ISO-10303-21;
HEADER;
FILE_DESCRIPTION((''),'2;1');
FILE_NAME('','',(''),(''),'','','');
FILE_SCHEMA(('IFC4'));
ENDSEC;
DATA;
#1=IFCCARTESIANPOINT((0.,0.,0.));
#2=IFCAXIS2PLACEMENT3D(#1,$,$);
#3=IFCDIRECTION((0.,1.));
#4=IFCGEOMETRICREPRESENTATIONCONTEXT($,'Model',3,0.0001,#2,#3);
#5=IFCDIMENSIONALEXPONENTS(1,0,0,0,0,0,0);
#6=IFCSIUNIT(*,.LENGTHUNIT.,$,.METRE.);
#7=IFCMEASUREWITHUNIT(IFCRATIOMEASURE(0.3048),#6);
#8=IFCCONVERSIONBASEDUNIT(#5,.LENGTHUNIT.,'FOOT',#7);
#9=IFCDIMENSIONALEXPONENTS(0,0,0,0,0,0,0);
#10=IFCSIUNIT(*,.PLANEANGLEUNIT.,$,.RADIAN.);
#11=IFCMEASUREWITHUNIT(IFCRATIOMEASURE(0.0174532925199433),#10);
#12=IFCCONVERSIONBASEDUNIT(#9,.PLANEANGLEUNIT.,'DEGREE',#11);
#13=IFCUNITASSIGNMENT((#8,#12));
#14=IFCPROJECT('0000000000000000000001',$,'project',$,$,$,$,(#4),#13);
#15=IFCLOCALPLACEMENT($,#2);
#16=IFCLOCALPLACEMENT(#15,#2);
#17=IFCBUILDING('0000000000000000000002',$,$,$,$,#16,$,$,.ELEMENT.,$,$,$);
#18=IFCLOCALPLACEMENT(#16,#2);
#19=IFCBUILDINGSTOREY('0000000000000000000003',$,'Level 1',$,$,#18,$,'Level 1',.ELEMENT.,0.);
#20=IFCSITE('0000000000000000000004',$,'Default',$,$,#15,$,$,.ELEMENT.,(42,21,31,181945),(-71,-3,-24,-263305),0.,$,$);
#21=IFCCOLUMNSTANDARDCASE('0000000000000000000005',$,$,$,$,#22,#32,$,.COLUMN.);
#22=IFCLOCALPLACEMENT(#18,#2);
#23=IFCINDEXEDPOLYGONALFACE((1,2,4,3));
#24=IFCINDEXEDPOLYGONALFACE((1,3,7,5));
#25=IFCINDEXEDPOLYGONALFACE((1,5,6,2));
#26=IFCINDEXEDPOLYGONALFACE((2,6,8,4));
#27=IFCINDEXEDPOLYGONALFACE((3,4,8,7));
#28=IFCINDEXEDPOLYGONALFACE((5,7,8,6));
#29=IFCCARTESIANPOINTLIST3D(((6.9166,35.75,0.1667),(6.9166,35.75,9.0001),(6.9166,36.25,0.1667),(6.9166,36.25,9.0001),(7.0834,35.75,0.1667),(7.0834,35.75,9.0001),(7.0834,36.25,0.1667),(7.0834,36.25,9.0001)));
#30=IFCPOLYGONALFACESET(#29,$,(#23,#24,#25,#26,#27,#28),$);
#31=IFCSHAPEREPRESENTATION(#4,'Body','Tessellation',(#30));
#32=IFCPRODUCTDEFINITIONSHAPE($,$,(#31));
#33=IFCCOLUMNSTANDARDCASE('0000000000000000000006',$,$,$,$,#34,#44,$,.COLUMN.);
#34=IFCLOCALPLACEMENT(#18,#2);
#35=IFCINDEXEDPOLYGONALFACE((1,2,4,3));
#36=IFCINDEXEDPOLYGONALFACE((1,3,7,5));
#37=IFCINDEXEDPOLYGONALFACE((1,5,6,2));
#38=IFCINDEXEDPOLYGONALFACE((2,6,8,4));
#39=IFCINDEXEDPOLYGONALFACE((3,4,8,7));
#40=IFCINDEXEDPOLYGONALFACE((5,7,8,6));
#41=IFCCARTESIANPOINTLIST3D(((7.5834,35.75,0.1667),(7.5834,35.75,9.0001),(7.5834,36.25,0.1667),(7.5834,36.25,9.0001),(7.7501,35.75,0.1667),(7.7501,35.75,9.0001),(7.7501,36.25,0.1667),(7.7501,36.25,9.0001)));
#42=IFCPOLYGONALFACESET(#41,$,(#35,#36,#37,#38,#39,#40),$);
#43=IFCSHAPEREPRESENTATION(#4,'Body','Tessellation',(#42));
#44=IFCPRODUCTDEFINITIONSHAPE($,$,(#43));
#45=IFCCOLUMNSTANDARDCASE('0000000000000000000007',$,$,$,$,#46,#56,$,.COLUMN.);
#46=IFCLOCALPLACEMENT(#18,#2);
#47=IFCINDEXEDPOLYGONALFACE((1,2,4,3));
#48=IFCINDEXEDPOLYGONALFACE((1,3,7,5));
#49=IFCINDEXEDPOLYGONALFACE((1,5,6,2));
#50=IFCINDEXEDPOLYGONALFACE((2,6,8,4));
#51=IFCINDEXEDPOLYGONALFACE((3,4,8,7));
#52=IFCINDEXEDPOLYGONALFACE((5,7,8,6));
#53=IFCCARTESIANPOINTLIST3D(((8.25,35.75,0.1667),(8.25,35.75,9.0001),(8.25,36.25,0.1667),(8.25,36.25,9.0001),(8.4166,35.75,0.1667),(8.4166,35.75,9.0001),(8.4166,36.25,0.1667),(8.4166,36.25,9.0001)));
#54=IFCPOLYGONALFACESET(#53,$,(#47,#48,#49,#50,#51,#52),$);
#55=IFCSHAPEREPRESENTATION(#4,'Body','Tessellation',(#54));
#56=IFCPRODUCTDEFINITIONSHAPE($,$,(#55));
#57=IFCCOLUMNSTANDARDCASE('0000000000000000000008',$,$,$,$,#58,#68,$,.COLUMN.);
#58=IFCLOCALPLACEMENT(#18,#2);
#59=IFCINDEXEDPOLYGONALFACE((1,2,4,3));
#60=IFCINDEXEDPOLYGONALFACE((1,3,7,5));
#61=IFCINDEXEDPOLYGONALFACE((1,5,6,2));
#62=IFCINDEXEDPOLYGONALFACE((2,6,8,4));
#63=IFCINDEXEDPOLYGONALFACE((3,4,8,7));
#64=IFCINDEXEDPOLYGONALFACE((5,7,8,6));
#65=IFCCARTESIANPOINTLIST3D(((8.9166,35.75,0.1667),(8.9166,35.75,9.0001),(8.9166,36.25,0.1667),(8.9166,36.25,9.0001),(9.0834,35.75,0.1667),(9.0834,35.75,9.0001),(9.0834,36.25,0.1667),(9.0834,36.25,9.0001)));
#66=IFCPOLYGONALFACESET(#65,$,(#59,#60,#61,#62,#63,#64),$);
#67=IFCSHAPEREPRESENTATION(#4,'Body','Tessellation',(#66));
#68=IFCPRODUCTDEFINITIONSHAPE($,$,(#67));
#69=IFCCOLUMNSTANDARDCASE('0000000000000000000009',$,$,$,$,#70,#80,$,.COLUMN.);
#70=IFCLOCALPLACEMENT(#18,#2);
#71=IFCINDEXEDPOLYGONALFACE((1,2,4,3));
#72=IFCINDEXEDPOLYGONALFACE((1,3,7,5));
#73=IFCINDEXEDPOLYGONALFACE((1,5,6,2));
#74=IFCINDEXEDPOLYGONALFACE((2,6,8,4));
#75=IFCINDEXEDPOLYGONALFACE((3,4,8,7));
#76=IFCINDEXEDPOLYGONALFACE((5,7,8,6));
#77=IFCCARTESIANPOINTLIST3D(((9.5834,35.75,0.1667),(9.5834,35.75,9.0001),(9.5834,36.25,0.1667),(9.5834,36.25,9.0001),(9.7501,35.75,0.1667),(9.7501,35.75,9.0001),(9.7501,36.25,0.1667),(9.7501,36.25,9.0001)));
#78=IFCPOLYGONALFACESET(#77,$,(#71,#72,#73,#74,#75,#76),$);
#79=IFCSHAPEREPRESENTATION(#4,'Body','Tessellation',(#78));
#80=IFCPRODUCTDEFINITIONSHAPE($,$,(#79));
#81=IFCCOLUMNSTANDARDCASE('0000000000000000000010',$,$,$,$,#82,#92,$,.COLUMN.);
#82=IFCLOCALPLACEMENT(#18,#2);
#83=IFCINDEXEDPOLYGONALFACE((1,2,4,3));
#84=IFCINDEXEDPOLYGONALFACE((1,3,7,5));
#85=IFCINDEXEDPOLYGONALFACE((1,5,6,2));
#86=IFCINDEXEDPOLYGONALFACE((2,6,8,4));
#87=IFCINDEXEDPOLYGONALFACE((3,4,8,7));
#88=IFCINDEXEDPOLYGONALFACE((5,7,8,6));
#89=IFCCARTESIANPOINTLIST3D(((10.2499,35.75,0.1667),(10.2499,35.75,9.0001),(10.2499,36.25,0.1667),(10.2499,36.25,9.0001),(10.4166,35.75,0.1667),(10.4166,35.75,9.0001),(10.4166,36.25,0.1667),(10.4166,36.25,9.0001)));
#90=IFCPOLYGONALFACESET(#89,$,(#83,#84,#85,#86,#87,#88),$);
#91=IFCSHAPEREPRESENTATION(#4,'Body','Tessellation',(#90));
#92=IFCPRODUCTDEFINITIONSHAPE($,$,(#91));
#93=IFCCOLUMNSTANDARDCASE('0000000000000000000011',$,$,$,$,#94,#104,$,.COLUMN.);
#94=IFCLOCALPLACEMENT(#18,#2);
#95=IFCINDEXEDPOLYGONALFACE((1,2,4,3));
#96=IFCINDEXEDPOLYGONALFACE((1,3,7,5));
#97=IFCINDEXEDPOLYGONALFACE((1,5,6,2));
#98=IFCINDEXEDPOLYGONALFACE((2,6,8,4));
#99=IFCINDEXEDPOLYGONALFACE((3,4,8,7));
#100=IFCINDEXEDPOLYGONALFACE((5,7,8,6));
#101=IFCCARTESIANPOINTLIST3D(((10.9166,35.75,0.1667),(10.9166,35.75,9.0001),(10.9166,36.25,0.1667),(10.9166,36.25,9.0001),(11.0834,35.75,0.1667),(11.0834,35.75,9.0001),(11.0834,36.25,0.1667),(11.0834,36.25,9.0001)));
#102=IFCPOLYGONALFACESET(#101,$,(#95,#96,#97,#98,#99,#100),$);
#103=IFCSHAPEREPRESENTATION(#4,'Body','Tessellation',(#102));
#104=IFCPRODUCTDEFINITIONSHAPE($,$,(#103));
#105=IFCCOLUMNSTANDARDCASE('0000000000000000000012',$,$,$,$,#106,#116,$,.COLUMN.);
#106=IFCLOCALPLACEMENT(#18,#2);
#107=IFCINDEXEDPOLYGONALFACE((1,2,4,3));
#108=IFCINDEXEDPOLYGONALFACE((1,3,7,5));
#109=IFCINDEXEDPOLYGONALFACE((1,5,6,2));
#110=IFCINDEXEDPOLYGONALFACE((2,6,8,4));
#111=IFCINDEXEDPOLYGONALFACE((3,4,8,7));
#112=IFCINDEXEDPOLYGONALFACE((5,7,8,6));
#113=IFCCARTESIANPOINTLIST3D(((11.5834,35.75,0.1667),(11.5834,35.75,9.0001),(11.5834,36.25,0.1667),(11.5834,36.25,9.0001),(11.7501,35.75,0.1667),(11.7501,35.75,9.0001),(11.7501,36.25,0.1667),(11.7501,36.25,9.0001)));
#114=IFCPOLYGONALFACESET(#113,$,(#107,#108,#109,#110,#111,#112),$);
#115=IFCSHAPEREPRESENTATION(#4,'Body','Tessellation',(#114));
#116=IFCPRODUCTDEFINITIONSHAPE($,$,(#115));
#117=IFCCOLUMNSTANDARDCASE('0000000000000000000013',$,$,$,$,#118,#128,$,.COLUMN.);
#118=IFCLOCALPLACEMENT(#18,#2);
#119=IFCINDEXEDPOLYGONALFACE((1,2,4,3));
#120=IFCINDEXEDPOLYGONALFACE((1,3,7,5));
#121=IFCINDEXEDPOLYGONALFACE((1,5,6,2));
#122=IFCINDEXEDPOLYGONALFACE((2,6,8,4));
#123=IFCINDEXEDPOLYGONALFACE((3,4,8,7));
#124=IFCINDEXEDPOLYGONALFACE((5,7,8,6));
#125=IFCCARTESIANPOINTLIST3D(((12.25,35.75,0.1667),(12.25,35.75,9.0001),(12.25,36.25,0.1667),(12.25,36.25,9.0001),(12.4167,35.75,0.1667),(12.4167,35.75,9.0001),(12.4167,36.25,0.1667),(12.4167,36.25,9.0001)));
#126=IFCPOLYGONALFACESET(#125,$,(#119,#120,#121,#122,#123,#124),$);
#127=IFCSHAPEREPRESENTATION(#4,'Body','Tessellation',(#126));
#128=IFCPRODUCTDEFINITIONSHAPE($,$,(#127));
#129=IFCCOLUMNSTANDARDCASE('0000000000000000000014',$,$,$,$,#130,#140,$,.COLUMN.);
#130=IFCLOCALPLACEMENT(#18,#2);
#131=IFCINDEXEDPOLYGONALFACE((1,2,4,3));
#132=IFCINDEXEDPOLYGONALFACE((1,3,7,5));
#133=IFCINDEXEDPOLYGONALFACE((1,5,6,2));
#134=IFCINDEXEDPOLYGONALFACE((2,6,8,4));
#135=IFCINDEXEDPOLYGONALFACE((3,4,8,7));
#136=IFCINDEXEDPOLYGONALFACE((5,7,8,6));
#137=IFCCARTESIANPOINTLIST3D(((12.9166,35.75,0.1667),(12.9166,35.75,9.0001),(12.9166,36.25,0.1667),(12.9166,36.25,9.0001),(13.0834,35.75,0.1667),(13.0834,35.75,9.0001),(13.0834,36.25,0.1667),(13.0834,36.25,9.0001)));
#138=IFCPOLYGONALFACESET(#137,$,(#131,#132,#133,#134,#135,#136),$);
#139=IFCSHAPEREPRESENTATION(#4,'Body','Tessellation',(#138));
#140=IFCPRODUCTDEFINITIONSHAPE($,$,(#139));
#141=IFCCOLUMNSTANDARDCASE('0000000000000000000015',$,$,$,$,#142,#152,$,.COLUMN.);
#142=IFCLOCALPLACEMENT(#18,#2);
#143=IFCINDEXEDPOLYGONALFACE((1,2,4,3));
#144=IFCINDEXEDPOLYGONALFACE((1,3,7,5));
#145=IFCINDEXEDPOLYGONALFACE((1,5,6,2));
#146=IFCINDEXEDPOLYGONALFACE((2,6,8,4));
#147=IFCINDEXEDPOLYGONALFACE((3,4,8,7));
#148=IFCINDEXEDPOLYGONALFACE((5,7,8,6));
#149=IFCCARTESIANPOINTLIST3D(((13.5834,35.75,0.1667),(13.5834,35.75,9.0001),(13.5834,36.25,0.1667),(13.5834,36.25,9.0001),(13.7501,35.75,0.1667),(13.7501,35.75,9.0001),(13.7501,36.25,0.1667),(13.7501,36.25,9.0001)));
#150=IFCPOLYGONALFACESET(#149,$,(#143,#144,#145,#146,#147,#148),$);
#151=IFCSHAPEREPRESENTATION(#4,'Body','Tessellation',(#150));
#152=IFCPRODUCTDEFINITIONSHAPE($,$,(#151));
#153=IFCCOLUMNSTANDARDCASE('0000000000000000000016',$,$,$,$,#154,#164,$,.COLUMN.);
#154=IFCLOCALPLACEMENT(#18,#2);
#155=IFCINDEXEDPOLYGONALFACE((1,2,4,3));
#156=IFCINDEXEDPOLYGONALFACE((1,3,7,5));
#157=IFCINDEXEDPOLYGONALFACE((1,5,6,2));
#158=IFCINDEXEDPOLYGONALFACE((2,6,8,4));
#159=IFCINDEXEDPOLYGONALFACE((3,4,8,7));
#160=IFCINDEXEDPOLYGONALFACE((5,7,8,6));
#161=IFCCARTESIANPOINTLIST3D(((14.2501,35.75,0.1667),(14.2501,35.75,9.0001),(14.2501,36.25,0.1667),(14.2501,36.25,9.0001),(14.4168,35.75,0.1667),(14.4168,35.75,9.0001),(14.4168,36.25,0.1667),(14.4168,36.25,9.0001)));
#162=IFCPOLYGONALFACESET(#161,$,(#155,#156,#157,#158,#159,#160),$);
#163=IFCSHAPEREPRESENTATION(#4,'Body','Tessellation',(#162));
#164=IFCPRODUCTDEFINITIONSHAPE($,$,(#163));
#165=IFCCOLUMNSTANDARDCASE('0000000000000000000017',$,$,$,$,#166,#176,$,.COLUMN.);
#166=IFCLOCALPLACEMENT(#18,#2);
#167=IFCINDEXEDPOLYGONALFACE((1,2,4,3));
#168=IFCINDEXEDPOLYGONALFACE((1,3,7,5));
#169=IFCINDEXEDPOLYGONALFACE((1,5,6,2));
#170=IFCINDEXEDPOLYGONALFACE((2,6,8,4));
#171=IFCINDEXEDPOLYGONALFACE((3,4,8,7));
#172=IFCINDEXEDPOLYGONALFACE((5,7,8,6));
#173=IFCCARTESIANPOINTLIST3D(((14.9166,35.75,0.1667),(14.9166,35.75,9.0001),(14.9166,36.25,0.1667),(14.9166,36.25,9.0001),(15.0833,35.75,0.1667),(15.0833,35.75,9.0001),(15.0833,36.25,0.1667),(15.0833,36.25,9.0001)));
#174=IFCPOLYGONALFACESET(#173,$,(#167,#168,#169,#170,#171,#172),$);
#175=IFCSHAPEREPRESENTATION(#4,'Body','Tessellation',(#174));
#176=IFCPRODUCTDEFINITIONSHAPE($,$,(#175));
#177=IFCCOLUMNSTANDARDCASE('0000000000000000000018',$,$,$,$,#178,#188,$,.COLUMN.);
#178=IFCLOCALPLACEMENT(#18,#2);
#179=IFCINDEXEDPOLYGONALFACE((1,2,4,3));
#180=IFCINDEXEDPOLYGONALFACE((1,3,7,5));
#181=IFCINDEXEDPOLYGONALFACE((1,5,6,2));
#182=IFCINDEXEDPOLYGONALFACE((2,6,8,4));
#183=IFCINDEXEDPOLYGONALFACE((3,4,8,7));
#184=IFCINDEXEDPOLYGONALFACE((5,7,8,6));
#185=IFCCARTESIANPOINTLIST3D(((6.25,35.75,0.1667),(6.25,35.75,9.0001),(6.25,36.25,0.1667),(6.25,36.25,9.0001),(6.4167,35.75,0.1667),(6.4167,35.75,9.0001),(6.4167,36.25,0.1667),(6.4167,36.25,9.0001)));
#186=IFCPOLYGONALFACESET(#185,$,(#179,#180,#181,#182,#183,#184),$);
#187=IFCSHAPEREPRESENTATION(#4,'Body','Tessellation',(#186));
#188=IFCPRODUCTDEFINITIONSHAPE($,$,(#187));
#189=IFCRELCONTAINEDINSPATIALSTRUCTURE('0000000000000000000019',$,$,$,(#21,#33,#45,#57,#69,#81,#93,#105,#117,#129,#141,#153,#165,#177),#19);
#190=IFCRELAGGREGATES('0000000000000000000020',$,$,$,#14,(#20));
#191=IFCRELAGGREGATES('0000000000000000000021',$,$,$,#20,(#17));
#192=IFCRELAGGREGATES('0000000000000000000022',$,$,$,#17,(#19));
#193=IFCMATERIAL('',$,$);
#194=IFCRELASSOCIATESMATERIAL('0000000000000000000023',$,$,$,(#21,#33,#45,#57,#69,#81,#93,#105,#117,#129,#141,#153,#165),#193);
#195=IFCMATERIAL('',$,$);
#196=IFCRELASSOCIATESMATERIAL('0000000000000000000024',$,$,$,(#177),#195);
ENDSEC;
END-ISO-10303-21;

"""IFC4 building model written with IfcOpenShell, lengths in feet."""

from ifc_helpers import new_model, entity, si_unit, converted_unit, direction, frame, origin, place, context, project, spatial, rectangle, extrude, material, element, save


model = new_model("IFC4")

# Units and contexts
model_context = context("Model", 3, precision=0.0001, world=origin(), true_north=direction((0.0, 1.0)))
ifc_project = project(units=[converted_unit("LENGTHUNIT", "FOOT", entity("IfcRatioMeasure", 0.3048), si_unit("LENGTHUNIT", "METRE"), dimensions=[1, 0, 0, 0, 0, 0, 0]), converted_unit("PLANEANGLEUNIT", "DEGREE", entity("IfcRatioMeasure", 0.0174532925199433), si_unit("PLANEANGLEUNIT", "RADIAN"), dimensions=[0, 0, 0, 0, 0, 0, 0])], contexts=[model_context])

# Site, building, storey
site_placement = place(None, origin())
site = spatial("IfcSite", under=ifc_project, at=site_placement, Name="Default", CompositionType="ELEMENT", RefLatitude=(42, 21, 31, 181945), RefLongitude=(-71, -3, -24, -263305), RefElevation=0.0)
building_placement = place(site_placement, origin())
building = spatial("IfcBuilding", under=site, at=building_placement, CompositionType="ELEMENT")
storey_placement = place(building_placement, origin())
storey = spatial("IfcBuildingStorey", under=building, at=storey_placement, Name="Level 1", LongName="Level 1", CompositionType="ELEMENT", Elevation=0.0)

# Columns
ifc_material_1 = material(Name="")
placement = place(storey_placement, frame((0.25, 36.0, 0.0)))
for number, where, z_axis, x_axis in (
    (1, (6.75, 0.0, 0.1667), (0.0, 0.0, 1.0), (1.0, 0.0, 0.0)),
    (2, (7.4167, 0.0, 0.1667), (0.0, 0.0, 1.0), (1.0, 0.0, 0.0)),
    (3, (8.0833, 0.0, 0.1667), (0.0, 0.0, 1.0), (1.0, 0.0, 0.0)),
    (4, (8.75, 0.0, 0.1667), (0.0, 0.0, 1.0), (1.0, 0.0, 0.0)),
    (5, (9.4167, 0.0, 0.1667), (0.0, 0.0, 1.0), (1.0, 0.0, 0.0)),
    (6, (10.0833, 0.0, 0.1667), (0.0, 0.0, 1.0), (1.0, 0.0, 0.0)),
    (7, (10.75, 0.0, 0.1667), (0.0, 0.0, 1.0), (1.0, 0.0, 0.0)),
    (8, (11.4167, 0.0, 0.1667), (0.0, 0.0, 1.0), (1.0, 0.0, 0.0)),
    (9, (12.0834, 0.0, 0.1667), (0.0, 0.0, 1.0), (1.0, 0.0, 0.0)),
    (10, (12.75, 0.0, 0.1667), (0.0, 0.0, 1.0), (1.0, 0.0, 0.0)),
    (11, (13.4167, 0.0, 0.1667), (0.0, 0.0, 1.0), (1.0, 0.0, 0.0)),
    (12, (14.0834, 0.0, 0.1667), (0.0, 0.0, 1.0), (1.0, 0.0, 0.0)),
    (13, (14.75, 0.0, 0.1667), (0.0, 0.0, 1.0), (1.0, 0.0, 0.0)),
):
    element("IfcColumnStandardCase", number, at=place(placement, frame(where, z_axis=z_axis, x_axis=x_axis)), inside=storey, material=ifc_material_1, PredefinedType="COLUMN", context=model_context, shape_type="SweptSolid", body=[
        extrude(rectangle(XDim=0.1667, YDim=0.5), origin(), (0.0, 0.0, 1.0), 8.8334),
    ])
ifc_material_2 = material(Name="")
for number, where, z_axis, x_axis in (
    (14, (6.0833, 0.0, 0.1667), (0.0, 0.0, 1.0), (1.0, 0.0, 0.0)),
):
    element("IfcColumnStandardCase", number, at=place(placement, frame(where, z_axis=z_axis, x_axis=x_axis)), inside=storey, material=ifc_material_2, PredefinedType="COLUMN", context=model_context, shape_type="SweptSolid", body=[
        extrude(rectangle(XDim=0.1667, YDim=0.5), origin(), (0.0, 0.0, 1.0), 8.8334),
    ])

save(model, "model.ifc")
